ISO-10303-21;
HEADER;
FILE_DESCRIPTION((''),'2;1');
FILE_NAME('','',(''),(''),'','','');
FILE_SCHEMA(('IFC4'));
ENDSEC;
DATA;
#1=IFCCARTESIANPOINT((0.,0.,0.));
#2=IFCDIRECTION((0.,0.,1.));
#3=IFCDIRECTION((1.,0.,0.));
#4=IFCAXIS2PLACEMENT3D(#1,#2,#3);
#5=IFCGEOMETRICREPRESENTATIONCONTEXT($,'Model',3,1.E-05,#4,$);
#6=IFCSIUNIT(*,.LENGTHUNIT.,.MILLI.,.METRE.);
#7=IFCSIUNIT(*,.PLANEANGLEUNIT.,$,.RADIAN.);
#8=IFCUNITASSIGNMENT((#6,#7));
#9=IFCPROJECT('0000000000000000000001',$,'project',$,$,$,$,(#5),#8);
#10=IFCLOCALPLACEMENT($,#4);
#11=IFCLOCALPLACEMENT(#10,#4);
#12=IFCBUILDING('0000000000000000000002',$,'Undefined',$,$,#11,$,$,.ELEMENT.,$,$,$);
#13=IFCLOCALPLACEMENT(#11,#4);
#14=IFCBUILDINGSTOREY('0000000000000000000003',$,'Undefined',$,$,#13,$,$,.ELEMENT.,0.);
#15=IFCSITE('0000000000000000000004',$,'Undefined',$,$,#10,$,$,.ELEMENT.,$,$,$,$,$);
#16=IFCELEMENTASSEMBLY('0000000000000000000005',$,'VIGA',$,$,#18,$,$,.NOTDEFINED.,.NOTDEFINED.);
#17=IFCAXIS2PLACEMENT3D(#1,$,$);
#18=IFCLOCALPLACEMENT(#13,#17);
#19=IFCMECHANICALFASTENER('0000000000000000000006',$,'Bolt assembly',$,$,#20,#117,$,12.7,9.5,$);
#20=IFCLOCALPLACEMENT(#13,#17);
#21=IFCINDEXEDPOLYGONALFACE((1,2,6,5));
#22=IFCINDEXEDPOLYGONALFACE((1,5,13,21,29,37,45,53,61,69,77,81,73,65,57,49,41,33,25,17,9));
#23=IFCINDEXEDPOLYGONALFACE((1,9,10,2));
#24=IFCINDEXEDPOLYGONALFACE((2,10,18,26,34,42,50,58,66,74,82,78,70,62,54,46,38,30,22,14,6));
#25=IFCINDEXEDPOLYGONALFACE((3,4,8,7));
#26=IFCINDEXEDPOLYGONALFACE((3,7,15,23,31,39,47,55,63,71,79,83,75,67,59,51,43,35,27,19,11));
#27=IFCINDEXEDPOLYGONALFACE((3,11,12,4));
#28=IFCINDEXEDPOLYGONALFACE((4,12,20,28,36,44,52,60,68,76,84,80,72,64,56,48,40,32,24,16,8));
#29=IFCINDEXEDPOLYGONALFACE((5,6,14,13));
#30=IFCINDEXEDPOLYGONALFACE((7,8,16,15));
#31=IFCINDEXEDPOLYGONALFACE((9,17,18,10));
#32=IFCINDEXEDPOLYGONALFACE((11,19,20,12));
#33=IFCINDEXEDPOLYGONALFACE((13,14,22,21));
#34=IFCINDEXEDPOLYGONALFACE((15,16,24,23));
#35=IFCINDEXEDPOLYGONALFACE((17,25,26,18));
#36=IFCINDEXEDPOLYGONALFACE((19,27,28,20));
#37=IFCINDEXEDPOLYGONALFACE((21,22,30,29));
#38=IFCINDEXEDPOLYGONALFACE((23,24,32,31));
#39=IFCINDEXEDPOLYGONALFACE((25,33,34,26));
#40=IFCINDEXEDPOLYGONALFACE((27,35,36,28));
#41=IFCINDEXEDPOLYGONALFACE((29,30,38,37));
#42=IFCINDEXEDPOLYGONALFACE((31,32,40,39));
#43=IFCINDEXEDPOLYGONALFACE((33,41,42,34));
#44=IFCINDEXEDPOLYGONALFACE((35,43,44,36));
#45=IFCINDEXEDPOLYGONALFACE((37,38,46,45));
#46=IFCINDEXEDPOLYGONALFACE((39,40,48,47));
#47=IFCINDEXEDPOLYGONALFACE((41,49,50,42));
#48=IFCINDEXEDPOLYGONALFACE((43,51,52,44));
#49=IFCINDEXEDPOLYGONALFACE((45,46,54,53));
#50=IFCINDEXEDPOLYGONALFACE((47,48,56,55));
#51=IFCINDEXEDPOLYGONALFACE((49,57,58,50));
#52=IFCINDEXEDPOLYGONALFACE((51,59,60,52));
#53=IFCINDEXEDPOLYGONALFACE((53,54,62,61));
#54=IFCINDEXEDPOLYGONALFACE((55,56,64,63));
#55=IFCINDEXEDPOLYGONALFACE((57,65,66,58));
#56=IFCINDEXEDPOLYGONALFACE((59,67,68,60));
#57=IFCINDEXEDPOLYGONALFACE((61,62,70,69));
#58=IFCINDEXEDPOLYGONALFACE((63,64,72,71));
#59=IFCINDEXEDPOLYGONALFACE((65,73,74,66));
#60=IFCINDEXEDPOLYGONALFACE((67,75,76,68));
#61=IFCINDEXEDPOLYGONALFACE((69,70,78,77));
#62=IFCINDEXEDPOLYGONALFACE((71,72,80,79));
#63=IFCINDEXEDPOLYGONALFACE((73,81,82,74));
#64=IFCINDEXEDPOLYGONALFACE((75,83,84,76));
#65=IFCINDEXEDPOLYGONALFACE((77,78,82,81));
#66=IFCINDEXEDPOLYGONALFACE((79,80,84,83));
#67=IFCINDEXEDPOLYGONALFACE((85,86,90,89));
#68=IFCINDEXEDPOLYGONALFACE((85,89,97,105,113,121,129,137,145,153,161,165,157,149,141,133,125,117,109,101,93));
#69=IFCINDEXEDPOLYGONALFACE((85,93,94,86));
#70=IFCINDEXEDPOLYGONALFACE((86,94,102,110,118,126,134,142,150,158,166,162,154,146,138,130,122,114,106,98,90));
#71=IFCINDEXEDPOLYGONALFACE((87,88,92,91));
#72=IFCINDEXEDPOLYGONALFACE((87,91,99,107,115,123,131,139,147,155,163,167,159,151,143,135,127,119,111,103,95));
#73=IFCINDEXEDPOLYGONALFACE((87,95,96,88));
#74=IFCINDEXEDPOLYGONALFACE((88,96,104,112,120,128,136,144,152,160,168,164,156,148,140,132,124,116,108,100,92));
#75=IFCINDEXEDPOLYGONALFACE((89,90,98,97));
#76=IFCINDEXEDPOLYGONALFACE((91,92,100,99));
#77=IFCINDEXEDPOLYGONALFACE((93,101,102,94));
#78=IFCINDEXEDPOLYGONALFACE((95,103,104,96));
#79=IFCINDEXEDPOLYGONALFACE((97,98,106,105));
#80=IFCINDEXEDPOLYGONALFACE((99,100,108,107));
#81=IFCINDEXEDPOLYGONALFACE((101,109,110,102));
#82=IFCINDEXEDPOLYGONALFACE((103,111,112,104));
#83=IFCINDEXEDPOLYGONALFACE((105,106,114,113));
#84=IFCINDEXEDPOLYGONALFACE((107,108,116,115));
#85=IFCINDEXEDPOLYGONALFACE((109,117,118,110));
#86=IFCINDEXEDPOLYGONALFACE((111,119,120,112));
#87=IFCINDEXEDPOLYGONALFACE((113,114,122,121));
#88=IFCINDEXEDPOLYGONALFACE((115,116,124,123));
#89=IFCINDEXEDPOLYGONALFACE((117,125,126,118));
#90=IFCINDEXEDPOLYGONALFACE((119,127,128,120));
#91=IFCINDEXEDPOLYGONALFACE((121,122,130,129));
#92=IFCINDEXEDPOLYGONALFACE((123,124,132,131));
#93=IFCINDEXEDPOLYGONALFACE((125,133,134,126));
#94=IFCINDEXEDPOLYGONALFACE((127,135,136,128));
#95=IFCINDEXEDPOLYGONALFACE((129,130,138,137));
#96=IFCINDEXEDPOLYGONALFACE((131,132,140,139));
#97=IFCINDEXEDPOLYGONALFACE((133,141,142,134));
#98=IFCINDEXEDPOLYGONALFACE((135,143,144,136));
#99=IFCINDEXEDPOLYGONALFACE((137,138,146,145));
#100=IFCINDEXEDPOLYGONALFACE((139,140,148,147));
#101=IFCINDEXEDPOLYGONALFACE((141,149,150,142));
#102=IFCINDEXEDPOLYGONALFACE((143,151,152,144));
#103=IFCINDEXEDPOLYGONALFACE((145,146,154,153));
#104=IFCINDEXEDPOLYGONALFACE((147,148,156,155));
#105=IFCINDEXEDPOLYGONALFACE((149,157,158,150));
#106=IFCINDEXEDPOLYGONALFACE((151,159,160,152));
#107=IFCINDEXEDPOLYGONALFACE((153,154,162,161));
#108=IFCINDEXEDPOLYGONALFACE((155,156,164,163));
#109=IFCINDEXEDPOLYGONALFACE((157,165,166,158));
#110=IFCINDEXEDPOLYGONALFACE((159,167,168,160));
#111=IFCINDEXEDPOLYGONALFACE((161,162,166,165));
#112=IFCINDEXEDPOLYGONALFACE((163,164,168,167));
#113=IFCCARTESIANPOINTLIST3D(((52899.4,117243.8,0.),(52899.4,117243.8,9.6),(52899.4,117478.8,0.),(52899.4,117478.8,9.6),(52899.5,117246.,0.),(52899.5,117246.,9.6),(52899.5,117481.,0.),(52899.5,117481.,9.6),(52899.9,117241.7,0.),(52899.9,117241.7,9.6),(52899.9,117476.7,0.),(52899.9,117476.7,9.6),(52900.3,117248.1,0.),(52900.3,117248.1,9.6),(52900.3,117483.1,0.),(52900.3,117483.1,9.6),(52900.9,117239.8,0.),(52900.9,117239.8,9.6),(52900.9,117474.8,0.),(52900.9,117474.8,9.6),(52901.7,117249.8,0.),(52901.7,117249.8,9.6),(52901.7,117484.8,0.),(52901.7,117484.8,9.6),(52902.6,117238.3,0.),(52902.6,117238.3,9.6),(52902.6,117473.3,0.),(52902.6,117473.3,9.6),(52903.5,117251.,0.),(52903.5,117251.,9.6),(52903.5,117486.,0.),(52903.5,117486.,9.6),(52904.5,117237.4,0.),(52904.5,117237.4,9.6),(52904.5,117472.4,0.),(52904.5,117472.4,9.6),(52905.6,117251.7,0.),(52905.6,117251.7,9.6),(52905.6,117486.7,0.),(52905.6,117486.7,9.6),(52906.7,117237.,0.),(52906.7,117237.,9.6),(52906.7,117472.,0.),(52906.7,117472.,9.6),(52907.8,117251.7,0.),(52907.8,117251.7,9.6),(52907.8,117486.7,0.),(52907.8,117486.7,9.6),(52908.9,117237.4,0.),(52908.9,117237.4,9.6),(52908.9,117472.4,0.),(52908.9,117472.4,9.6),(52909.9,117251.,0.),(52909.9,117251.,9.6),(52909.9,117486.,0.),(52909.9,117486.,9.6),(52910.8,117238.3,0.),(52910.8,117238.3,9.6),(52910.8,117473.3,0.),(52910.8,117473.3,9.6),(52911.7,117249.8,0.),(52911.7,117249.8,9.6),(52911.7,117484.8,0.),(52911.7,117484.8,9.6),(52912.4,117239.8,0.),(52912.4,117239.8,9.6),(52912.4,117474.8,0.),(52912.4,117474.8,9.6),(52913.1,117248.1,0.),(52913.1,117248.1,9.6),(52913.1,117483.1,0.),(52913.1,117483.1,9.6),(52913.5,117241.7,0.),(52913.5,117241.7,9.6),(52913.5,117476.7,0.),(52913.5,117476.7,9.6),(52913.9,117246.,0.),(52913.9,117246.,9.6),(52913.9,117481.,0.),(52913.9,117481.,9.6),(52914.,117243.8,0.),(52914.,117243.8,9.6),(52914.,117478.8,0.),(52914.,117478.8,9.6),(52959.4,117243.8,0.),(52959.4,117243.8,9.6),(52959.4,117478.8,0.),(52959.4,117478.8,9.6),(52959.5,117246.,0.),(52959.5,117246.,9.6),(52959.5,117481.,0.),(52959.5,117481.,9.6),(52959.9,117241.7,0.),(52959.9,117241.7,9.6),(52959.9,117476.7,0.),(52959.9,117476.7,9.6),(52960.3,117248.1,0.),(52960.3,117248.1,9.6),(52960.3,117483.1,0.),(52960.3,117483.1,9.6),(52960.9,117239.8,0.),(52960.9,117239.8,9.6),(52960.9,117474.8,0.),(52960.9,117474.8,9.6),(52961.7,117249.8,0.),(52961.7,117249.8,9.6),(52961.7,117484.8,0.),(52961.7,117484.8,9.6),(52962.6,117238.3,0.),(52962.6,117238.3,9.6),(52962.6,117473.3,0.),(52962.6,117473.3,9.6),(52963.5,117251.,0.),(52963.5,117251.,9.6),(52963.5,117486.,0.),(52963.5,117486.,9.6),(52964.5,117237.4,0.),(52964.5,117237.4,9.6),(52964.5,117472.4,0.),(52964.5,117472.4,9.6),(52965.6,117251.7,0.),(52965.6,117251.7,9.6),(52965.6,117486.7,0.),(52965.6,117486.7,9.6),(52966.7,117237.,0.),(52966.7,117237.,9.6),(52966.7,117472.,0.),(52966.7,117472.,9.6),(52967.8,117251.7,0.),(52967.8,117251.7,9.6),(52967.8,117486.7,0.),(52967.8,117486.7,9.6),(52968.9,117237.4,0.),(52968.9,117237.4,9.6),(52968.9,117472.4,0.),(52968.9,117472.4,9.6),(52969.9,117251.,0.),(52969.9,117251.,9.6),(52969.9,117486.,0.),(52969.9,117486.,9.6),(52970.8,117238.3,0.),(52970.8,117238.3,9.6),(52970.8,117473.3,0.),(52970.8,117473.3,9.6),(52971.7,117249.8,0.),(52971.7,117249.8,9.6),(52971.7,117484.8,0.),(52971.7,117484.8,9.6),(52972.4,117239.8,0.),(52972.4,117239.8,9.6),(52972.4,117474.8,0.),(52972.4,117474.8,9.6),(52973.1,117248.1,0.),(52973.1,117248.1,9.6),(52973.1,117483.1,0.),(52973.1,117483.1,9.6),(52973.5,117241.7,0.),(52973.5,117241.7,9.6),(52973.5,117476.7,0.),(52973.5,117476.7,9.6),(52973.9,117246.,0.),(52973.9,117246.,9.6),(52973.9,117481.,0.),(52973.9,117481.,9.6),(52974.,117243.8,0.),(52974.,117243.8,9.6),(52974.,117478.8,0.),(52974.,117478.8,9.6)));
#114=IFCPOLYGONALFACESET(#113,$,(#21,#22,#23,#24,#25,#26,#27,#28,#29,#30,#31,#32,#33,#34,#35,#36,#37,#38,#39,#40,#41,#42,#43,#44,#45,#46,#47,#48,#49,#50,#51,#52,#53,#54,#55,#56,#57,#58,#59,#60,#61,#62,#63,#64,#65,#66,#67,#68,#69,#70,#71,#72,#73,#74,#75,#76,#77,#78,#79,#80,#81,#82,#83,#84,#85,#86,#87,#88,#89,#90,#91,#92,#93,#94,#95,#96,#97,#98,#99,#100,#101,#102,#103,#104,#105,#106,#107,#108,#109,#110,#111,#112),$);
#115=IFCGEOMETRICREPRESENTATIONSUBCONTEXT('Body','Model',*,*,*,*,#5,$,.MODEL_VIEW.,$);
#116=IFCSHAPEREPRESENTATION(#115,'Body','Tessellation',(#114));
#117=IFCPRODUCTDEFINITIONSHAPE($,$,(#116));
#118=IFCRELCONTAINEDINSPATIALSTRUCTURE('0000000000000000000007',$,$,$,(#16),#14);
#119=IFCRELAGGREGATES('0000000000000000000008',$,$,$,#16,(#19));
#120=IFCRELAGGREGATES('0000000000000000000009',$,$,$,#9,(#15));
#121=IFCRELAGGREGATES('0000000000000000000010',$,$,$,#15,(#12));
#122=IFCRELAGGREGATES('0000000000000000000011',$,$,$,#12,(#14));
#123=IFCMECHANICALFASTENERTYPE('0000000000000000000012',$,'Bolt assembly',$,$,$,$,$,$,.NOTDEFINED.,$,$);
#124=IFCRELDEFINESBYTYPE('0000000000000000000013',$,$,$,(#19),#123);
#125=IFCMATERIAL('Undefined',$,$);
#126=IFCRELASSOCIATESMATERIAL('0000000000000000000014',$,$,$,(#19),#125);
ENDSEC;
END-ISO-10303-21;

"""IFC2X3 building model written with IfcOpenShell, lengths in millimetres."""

from ifc_helpers import new_model, si_unit, frame, origin_with_axes, origin_2d_with_axis, place, context, subcontext, project, spatial, circle, extrude, source, transform, mapped, material, type_object, element, aggregate, save


model = new_model("IFC2X3")

# Units and contexts
model_context = context("Model", 3, precision=1e-05, world=origin_with_axes())
body_context = subcontext(model_context, "Body", "Model", "MODEL_VIEW")
ifc_project = project(units=[si_unit("LENGTHUNIT", "METRE", prefix="MILLI"), si_unit("PLANEANGLEUNIT", "RADIAN")], contexts=[model_context])

# Site, building, storey
site_placement = place(None, origin_with_axes())
site = spatial("IfcSite", under=ifc_project, at=site_placement, Name="Undefined", CompositionType="ELEMENT")
building_placement = place(site_placement, origin_with_axes())
building = spatial("IfcBuilding", under=site, at=building_placement, Name="Undefined", CompositionType="ELEMENT")
storey_placement = place(building_placement, origin_with_axes())
storey = spatial("IfcBuildingStorey", under=building, at=storey_placement, Name="Undefined", CompositionType="ELEMENT", Elevation=0.0)

# Element assembly
assembly_1_placement = place(storey_placement, origin_with_axes())
assembly_1 = element("IfcElementAssembly", 1, at=assembly_1_placement, inside=storey, Name="VIGA", AssemblyPlace="NOTDEFINED", PredefinedType="NOTDEFINED")

# Shared definitions
ifc_material_1 = material(Name="Undefined")
mechanical_fastener_type = type_object("IfcMechanicalFastenerType", Name="Bolt assembly")

# Mechanical fastener
shared_shape_1 = source(origin_with_axes(), body_context, "Body", "SweptSolid", [
    extrude(circle(Radius=7.3, at=origin_2d_with_axis()), frame((0.0, -9.5, 0.0), z_axis=(0.0, 1.0, 0.0), x_axis=(1.0, 0.0, 0.0)), (0.0, 0.0, 1.0), 9.6),
])
mechanical_fastener_1_placement = place(assembly_1_placement, frame((52936.7, 117479.4, 9.5), z_axis=(-1.0, 0.0, 0.0), x_axis=(0.0, -1.0, 0.0)))
mechanical_fastener_1 = element("IfcMechanicalFastener", 2, at=mechanical_fastener_1_placement, type_object=mechanical_fastener_type, material=ifc_material_1, Name="Bolt assembly", NominalDiameter=12.7, NominalLength=9.5, context=body_context, shape_type="MappedRepresentation", body=[
    mapped(shared_shape_1, transform((0.0, 0.0, 30.0))),
    mapped(shared_shape_1, transform((235.0, 0.0, 30.0))),
    mapped(shared_shape_1, transform((0.0, 0.0, -30.0))),
    mapped(shared_shape_1, transform((235.0, 0.0, -30.0))),
])
aggregate(assembly_1, [mechanical_fastener_1])

save(model, "model.ifc")
